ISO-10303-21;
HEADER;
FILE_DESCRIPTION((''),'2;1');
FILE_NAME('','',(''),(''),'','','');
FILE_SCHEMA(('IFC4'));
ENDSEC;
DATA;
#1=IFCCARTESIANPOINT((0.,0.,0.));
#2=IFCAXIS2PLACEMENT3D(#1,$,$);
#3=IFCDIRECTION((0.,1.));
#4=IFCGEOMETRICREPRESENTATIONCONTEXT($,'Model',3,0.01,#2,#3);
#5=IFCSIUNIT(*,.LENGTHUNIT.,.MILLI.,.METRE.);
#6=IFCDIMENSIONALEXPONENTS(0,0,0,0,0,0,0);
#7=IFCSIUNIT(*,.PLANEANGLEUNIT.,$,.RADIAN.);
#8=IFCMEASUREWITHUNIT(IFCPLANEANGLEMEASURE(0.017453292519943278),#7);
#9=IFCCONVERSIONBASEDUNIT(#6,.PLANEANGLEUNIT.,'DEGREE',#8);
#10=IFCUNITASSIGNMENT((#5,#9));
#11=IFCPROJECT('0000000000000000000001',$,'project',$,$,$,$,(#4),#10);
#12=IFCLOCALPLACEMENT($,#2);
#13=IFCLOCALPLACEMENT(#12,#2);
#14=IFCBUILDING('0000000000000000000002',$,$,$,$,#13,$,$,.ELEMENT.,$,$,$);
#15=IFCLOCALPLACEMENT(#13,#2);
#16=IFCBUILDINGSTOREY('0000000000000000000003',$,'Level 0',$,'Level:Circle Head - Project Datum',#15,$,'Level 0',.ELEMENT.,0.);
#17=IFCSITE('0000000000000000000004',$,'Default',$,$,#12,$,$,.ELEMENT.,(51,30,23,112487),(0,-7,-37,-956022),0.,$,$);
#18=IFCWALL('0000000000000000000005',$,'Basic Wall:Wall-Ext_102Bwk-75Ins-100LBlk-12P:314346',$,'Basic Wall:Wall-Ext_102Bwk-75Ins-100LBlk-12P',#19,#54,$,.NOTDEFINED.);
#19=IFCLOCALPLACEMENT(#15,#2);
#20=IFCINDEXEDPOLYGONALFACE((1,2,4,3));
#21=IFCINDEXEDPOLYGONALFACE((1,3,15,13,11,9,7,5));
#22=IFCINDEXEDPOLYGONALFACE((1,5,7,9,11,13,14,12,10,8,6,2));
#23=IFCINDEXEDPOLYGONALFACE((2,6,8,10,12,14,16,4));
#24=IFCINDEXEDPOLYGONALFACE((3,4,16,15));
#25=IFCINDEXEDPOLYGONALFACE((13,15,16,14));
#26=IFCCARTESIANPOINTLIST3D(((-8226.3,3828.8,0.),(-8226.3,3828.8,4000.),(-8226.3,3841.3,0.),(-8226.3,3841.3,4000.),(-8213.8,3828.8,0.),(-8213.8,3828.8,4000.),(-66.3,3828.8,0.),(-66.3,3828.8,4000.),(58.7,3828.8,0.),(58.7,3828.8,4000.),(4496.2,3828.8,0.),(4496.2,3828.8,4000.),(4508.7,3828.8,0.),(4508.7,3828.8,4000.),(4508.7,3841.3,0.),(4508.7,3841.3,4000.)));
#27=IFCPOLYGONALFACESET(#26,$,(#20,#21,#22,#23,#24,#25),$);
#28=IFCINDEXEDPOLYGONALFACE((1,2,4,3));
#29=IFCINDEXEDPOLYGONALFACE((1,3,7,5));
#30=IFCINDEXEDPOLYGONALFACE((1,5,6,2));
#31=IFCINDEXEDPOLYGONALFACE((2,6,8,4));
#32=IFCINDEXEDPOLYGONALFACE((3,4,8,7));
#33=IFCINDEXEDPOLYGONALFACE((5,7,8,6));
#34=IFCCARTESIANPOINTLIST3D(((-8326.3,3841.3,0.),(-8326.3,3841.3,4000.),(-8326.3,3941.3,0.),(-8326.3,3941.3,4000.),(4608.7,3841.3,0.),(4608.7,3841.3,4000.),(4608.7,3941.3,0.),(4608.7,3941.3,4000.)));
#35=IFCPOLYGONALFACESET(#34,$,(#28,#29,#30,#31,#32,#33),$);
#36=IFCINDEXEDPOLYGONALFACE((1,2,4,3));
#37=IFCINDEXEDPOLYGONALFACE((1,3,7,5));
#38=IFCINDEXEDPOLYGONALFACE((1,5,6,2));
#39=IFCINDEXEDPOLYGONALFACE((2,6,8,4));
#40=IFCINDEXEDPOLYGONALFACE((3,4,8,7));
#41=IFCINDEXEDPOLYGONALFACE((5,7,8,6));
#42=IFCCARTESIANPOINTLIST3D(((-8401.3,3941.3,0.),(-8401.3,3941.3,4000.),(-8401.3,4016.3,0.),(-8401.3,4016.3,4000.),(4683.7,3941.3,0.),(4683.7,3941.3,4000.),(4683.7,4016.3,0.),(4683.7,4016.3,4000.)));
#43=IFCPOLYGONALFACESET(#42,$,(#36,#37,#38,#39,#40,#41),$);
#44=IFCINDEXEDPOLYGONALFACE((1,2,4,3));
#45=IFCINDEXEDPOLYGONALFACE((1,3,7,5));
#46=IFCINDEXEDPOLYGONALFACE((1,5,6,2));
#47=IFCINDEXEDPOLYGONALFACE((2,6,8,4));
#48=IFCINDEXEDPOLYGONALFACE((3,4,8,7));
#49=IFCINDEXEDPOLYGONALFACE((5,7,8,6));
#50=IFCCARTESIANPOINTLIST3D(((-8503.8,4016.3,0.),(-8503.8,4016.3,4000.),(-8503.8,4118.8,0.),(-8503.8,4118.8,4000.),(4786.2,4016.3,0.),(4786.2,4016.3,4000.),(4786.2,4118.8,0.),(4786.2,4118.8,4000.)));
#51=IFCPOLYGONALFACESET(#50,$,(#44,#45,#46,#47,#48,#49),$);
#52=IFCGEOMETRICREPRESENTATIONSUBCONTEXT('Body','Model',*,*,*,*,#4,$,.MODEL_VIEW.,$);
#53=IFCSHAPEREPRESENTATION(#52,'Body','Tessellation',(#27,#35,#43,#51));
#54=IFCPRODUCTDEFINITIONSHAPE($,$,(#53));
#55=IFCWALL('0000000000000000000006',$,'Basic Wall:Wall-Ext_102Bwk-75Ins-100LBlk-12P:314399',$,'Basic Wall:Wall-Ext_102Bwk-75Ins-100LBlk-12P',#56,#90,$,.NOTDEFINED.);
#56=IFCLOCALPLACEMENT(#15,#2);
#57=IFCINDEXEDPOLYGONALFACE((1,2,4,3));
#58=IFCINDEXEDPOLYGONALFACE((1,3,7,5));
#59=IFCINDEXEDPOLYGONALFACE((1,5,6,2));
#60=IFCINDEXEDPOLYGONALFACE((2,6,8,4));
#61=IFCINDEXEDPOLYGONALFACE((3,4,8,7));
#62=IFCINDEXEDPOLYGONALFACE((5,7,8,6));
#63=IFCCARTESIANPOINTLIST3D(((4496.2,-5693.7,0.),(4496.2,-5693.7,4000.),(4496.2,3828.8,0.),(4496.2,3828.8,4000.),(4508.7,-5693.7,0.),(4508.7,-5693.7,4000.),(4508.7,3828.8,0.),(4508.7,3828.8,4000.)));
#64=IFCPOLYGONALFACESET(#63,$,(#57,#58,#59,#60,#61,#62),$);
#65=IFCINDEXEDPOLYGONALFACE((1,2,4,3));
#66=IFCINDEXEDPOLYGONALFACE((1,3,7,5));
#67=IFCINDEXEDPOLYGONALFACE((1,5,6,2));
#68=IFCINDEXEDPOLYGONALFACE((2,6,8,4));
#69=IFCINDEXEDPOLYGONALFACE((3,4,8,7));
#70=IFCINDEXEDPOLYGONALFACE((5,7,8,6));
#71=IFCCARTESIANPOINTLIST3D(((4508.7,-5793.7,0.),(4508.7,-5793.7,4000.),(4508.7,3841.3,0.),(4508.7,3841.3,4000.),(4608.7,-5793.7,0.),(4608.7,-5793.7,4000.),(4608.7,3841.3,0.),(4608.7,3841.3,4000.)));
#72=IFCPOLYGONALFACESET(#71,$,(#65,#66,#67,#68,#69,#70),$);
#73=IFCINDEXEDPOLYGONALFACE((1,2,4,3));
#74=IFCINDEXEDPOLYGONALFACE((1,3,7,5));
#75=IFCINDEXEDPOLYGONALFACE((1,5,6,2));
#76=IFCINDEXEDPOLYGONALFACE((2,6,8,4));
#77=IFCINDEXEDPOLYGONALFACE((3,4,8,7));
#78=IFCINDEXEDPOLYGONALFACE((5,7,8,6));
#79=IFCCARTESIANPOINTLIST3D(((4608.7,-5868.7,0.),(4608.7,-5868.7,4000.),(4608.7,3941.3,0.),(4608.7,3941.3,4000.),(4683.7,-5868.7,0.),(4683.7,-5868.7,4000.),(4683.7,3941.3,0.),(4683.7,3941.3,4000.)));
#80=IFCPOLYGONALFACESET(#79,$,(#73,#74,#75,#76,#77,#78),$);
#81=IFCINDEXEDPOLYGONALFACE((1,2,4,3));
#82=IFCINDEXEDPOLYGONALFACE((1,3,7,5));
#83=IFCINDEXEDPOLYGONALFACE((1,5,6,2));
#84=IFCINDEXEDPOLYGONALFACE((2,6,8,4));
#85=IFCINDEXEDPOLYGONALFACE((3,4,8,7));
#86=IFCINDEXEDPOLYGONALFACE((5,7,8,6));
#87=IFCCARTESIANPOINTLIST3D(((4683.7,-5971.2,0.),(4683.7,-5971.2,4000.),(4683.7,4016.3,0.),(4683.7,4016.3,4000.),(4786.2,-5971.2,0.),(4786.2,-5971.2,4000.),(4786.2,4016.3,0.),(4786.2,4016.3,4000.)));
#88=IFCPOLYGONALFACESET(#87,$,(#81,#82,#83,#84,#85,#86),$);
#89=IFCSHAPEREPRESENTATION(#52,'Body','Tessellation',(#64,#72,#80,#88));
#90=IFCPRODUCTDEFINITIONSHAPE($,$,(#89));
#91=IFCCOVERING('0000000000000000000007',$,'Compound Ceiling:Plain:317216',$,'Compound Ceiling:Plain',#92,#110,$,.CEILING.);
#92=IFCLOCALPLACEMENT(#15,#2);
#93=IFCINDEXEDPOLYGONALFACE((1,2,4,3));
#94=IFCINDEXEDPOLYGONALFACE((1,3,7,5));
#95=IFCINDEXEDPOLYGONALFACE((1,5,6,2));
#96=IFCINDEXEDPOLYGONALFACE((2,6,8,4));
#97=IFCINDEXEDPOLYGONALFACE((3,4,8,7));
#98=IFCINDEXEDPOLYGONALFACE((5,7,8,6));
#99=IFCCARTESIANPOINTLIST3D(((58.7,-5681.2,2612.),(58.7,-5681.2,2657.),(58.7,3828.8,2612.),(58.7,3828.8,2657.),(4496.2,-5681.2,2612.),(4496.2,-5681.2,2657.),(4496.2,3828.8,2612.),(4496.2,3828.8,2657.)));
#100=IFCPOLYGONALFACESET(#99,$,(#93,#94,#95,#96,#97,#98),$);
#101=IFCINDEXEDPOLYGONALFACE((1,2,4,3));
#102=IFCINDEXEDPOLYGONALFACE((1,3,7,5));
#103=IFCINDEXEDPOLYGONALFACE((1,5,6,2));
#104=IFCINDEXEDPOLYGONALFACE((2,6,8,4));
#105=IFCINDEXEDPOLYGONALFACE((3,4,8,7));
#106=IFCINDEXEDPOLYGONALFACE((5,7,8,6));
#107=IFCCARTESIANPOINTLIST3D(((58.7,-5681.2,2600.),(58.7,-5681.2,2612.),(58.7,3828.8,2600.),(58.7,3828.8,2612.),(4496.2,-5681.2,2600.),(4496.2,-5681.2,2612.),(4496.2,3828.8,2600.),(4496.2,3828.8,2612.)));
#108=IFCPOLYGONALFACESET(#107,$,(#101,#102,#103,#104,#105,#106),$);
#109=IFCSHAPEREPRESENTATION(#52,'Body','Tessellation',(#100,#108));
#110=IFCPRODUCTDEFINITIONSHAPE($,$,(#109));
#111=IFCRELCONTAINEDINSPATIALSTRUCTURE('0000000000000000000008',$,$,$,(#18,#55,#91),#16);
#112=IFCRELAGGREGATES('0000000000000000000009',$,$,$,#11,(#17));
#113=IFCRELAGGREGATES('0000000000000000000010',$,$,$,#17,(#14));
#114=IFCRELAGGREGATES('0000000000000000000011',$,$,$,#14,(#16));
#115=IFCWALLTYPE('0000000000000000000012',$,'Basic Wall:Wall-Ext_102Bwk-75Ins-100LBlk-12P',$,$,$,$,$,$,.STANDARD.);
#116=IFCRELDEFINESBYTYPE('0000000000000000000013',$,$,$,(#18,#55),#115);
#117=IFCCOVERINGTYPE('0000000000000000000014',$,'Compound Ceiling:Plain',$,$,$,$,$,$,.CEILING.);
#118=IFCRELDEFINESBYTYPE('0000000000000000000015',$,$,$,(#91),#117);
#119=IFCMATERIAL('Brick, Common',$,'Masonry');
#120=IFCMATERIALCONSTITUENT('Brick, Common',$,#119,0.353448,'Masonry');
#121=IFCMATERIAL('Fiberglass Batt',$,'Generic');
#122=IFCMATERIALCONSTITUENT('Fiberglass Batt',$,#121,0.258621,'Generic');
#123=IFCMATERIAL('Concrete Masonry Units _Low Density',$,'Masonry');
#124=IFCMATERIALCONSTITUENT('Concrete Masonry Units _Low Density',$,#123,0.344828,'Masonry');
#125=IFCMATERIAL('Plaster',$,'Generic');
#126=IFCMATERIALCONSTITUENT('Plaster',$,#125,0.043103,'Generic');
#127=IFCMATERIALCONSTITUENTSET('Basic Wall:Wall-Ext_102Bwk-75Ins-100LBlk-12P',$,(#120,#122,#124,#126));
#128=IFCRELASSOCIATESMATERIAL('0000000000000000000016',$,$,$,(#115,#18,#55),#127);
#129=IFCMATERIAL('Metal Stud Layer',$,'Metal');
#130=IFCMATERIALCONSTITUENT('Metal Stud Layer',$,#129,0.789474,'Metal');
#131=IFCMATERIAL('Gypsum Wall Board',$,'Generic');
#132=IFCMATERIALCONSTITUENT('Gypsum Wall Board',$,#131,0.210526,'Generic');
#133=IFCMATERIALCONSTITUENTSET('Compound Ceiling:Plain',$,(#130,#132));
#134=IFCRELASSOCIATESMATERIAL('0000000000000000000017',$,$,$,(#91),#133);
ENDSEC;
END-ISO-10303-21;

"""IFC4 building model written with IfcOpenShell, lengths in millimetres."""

from ifc_helpers import new_model, entity, si_unit, converted_unit, direction, frame, origin, place, context, subcontext, project, spatial, indexed_curve, outline, extrude, material, constituent, constituent_set, type_object, element, save


model = new_model("IFC4")

# Units and contexts
model_context = context("Model", 3, precision=0.01, world=origin(), true_north=direction((0.0, 1.0)))
body_context = subcontext(model_context, "Body", "Model", "MODEL_VIEW")
ifc_project = project(units=[si_unit("LENGTHUNIT", "METRE", prefix="MILLI"), converted_unit("PLANEANGLEUNIT", "DEGREE", entity("IfcPlaneAngleMeasure", 0.017453292519943278), si_unit("PLANEANGLEUNIT", "RADIAN"), dimensions=[0, 0, 0, 0, 0, 0, 0])], contexts=[model_context])

# Site, building, storey
site_placement = place(None, origin())
site = spatial("IfcSite", under=ifc_project, at=site_placement, Name="Default", CompositionType="ELEMENT", RefLatitude=(51, 30, 23, 112487), RefLongitude=(0, -7, -37, -956022), RefElevation=0.0)
building_placement = place(site_placement, origin())
building = spatial("IfcBuilding", under=site, at=building_placement, CompositionType="ELEMENT")
storey_placement = place(building_placement, origin())
storey = spatial("IfcBuildingStorey", under=building, at=storey_placement, Name="Level 0", ObjectType="Level:Circle Head - Project Datum", LongName="Level 0", CompositionType="ELEMENT", Elevation=0.0)

# Shared definitions
ifc_material_1 = material(Name="Plaster", Category="Generic")

# Walls
ifc_material_2 = material(Name="Brick, Common", Category="Masonry")
ifc_constituent_1 = constituent(ifc_material_2, Name="Brick, Common", Category="Masonry", fraction=0.353448)
ifc_material_3 = material(Name="Fiberglass Batt", Category="Generic")
ifc_constituent_2 = constituent(ifc_material_3, Name="Fiberglass Batt", Category="Generic", fraction=0.258621)
ifc_material_4 = material(Name="Concrete Masonry Units _Low Density", Category="Masonry")
ifc_constituent_3 = constituent(ifc_material_4, Name="Concrete Masonry Units _Low Density", Category="Masonry", fraction=0.344828)
ifc_constituent_4 = constituent(ifc_material_1, Name="Plaster", Category="Generic", fraction=0.043103)
ifc_constituent_set_1 = constituent_set(constituents=[ifc_constituent_1, ifc_constituent_2, ifc_constituent_3, ifc_constituent_4], Name="Basic Wall:Wall-Ext_102Bwk-75Ins-100LBlk-12P")
wall_type_1 = type_object("IfcWallType", Name="Basic Wall:Wall-Ext_102Bwk-75Ins-100LBlk-12P", PredefinedType="STANDARD", material=ifc_constituent_set_1)
wall_1_placement = place(storey_placement, frame((-8503.8, 3973.8, 0.0)))
element("IfcWall", 1, at=wall_1_placement, inside=storey, type_object=wall_type_1, material=ifc_constituent_set_1, Name="Basic Wall:Wall-Ext_102Bwk-75Ins-100LBlk-12P:314346", ObjectType="Basic Wall:Wall-Ext_102Bwk-75Ins-100LBlk-12P", PredefinedType="NOTDEFINED", context=body_context, shape_type="SweptSolid", body=[
    extrude(outline(indexed_curve([(-6818.8, -3.1), (1328.8, -3.1), (1453.8, -3.1), (5891.3, -3.1), (5903.8, -3.1), (5903.8, 9.4), (-6831.3, 9.4), (-6831.3, -3.1), (-6818.8, -3.1)], self_intersect=False)), frame((7108.8, -141.9, 0.0)), (0.0, 0.0, 1.0), 4000.0),
    extrude(outline(indexed_curve([(-6467.5, -50.0), (6467.5, -50.0), (6467.5, 50.0), (-6467.5, 50.0), (-6467.5, -50.0)], self_intersect=False)), frame((6645.0, -82.5, 0.0)), (0.0, 0.0, 1.0), 4000.0),
    extrude(outline(indexed_curve([(-6542.5, -37.5), (6542.5, -37.5), (6542.5, 37.5), (-6542.5, 37.5), (-6542.5, -37.5)], self_intersect=False)), frame((6645.0, 5.0, 0.0)), (0.0, 0.0, 1.0), 4000.0),
    extrude(outline(indexed_curve([(-51.3, -6645.0), (51.2, -6645.0), (51.3, 6645.0), (-51.2, 6645.0), (-51.3, -6645.0)], self_intersect=False)), frame((6645.0, 93.8, 0.0), z_axis=(0.0, 0.0, 1.0), x_axis=(0.0, -1.0, 0.0)), (0.0, 0.0, 1.0), 4000.0),
])
wall_2_placement = place(storey_placement, frame((4641.2, 3828.8, 0.0), z_axis=(0.0, 0.0, 1.0), x_axis=(0.0, -1.0, 0.0)))
element("IfcWall", 2, at=wall_2_placement, inside=storey, type_object=wall_type_1, material=ifc_constituent_set_1, Name="Basic Wall:Wall-Ext_102Bwk-75Ins-100LBlk-12P:314399", ObjectType="Basic Wall:Wall-Ext_102Bwk-75Ins-100LBlk-12P", PredefinedType="NOTDEFINED", context=body_context, shape_type="SweptSolid", body=[
    extrude(outline(indexed_curve([(-6.3, -4761.3), (6.2, -4761.3), (6.3, 4761.2), (-6.2, 4761.2), (-6.3, -4761.3)], self_intersect=False)), frame((4761.3, -138.7, 0.0), z_axis=(0.0, 0.0, 1.0), x_axis=(0.0, 1.0, 0.0)), (0.0, 0.0, 1.0), 4000.0),
    extrude(outline(indexed_curve([(-4817.5, -50.0), (4817.5, -50.0), (4817.5, 50.0), (-4817.5, 50.0), (-4817.5, -50.0)], self_intersect=False)), frame((4805.0, -82.5, 0.0)), (0.0, 0.0, 1.0), 4000.0),
    extrude(outline(indexed_curve([(-4905.0, -37.5), (4905.0, -37.5), (4905.0, 37.5), (-4905.0, 37.5), (-4905.0, -37.5)], self_intersect=False)), frame((4792.5, 5.0, 0.0)), (0.0, 0.0, 1.0), 4000.0),
    extrude(outline(indexed_curve([(-51.2, -4993.8), (51.3, -4993.8), (51.2, 4993.8), (-51.3, 4993.8), (-51.2, -4993.8)], self_intersect=False)), frame((4806.2, 93.8, 0.0), z_axis=(0.0, 0.0, 1.0), x_axis=(0.0, -1.0, 0.0)), (0.0, 0.0, 1.0), 4000.0),
])

# Covering
ifc_material_5 = material(Name="Metal Stud Layer", Category="Metal")
ifc_constituent_5 = constituent(ifc_material_5, Name="Metal Stud Layer", Category="Metal", fraction=0.789474)
ifc_material_6 = material(Name="Gypsum Wall Board", Category="Generic")
ifc_constituent_6 = constituent(ifc_material_6, Name="Gypsum Wall Board", Category="Generic", fraction=0.210526)
ifc_constituent_set_2 = constituent_set(constituents=[ifc_constituent_5, ifc_constituent_6], Name="Compound Ceiling:Plain")
covering_type = type_object("IfcCoveringType", Name="Compound Ceiling:Plain", PredefinedType="CEILING")
covering_placement = place(storey_placement, origin())
element("IfcCovering", 3, at=covering_placement, inside=storey, type_object=covering_type, material=ifc_constituent_set_2, Name="Compound Ceiling:Plain:317216", ObjectType="Compound Ceiling:Plain", PredefinedType="CEILING", context=body_context, shape_type="SweptSolid", body=[
    extrude(outline(indexed_curve([(-4755.0, -2218.7), (4755.0, -2218.7), (4755.0, 2218.8), (-4755.0, 2218.7), (-4755.0, -2218.7)], self_intersect=False)), frame((2277.5, -926.2, 2612.0), z_axis=(0.0, 0.0, 1.0), x_axis=(0.0, 1.0, 0.0)), (0.0, 0.0, 1.0), 45.0),
    extrude(outline(indexed_curve([(-2218.7, -4755.0), (2218.7, -4755.0), (2218.7, 4755.0), (-2218.8, 4755.0), (-2218.7, -4755.0)], self_intersect=False)), frame((2277.5, -926.2, 2600.0)), (0.0, 0.0, 1.0), 12.0),
])

save(model, "model.ifc")
